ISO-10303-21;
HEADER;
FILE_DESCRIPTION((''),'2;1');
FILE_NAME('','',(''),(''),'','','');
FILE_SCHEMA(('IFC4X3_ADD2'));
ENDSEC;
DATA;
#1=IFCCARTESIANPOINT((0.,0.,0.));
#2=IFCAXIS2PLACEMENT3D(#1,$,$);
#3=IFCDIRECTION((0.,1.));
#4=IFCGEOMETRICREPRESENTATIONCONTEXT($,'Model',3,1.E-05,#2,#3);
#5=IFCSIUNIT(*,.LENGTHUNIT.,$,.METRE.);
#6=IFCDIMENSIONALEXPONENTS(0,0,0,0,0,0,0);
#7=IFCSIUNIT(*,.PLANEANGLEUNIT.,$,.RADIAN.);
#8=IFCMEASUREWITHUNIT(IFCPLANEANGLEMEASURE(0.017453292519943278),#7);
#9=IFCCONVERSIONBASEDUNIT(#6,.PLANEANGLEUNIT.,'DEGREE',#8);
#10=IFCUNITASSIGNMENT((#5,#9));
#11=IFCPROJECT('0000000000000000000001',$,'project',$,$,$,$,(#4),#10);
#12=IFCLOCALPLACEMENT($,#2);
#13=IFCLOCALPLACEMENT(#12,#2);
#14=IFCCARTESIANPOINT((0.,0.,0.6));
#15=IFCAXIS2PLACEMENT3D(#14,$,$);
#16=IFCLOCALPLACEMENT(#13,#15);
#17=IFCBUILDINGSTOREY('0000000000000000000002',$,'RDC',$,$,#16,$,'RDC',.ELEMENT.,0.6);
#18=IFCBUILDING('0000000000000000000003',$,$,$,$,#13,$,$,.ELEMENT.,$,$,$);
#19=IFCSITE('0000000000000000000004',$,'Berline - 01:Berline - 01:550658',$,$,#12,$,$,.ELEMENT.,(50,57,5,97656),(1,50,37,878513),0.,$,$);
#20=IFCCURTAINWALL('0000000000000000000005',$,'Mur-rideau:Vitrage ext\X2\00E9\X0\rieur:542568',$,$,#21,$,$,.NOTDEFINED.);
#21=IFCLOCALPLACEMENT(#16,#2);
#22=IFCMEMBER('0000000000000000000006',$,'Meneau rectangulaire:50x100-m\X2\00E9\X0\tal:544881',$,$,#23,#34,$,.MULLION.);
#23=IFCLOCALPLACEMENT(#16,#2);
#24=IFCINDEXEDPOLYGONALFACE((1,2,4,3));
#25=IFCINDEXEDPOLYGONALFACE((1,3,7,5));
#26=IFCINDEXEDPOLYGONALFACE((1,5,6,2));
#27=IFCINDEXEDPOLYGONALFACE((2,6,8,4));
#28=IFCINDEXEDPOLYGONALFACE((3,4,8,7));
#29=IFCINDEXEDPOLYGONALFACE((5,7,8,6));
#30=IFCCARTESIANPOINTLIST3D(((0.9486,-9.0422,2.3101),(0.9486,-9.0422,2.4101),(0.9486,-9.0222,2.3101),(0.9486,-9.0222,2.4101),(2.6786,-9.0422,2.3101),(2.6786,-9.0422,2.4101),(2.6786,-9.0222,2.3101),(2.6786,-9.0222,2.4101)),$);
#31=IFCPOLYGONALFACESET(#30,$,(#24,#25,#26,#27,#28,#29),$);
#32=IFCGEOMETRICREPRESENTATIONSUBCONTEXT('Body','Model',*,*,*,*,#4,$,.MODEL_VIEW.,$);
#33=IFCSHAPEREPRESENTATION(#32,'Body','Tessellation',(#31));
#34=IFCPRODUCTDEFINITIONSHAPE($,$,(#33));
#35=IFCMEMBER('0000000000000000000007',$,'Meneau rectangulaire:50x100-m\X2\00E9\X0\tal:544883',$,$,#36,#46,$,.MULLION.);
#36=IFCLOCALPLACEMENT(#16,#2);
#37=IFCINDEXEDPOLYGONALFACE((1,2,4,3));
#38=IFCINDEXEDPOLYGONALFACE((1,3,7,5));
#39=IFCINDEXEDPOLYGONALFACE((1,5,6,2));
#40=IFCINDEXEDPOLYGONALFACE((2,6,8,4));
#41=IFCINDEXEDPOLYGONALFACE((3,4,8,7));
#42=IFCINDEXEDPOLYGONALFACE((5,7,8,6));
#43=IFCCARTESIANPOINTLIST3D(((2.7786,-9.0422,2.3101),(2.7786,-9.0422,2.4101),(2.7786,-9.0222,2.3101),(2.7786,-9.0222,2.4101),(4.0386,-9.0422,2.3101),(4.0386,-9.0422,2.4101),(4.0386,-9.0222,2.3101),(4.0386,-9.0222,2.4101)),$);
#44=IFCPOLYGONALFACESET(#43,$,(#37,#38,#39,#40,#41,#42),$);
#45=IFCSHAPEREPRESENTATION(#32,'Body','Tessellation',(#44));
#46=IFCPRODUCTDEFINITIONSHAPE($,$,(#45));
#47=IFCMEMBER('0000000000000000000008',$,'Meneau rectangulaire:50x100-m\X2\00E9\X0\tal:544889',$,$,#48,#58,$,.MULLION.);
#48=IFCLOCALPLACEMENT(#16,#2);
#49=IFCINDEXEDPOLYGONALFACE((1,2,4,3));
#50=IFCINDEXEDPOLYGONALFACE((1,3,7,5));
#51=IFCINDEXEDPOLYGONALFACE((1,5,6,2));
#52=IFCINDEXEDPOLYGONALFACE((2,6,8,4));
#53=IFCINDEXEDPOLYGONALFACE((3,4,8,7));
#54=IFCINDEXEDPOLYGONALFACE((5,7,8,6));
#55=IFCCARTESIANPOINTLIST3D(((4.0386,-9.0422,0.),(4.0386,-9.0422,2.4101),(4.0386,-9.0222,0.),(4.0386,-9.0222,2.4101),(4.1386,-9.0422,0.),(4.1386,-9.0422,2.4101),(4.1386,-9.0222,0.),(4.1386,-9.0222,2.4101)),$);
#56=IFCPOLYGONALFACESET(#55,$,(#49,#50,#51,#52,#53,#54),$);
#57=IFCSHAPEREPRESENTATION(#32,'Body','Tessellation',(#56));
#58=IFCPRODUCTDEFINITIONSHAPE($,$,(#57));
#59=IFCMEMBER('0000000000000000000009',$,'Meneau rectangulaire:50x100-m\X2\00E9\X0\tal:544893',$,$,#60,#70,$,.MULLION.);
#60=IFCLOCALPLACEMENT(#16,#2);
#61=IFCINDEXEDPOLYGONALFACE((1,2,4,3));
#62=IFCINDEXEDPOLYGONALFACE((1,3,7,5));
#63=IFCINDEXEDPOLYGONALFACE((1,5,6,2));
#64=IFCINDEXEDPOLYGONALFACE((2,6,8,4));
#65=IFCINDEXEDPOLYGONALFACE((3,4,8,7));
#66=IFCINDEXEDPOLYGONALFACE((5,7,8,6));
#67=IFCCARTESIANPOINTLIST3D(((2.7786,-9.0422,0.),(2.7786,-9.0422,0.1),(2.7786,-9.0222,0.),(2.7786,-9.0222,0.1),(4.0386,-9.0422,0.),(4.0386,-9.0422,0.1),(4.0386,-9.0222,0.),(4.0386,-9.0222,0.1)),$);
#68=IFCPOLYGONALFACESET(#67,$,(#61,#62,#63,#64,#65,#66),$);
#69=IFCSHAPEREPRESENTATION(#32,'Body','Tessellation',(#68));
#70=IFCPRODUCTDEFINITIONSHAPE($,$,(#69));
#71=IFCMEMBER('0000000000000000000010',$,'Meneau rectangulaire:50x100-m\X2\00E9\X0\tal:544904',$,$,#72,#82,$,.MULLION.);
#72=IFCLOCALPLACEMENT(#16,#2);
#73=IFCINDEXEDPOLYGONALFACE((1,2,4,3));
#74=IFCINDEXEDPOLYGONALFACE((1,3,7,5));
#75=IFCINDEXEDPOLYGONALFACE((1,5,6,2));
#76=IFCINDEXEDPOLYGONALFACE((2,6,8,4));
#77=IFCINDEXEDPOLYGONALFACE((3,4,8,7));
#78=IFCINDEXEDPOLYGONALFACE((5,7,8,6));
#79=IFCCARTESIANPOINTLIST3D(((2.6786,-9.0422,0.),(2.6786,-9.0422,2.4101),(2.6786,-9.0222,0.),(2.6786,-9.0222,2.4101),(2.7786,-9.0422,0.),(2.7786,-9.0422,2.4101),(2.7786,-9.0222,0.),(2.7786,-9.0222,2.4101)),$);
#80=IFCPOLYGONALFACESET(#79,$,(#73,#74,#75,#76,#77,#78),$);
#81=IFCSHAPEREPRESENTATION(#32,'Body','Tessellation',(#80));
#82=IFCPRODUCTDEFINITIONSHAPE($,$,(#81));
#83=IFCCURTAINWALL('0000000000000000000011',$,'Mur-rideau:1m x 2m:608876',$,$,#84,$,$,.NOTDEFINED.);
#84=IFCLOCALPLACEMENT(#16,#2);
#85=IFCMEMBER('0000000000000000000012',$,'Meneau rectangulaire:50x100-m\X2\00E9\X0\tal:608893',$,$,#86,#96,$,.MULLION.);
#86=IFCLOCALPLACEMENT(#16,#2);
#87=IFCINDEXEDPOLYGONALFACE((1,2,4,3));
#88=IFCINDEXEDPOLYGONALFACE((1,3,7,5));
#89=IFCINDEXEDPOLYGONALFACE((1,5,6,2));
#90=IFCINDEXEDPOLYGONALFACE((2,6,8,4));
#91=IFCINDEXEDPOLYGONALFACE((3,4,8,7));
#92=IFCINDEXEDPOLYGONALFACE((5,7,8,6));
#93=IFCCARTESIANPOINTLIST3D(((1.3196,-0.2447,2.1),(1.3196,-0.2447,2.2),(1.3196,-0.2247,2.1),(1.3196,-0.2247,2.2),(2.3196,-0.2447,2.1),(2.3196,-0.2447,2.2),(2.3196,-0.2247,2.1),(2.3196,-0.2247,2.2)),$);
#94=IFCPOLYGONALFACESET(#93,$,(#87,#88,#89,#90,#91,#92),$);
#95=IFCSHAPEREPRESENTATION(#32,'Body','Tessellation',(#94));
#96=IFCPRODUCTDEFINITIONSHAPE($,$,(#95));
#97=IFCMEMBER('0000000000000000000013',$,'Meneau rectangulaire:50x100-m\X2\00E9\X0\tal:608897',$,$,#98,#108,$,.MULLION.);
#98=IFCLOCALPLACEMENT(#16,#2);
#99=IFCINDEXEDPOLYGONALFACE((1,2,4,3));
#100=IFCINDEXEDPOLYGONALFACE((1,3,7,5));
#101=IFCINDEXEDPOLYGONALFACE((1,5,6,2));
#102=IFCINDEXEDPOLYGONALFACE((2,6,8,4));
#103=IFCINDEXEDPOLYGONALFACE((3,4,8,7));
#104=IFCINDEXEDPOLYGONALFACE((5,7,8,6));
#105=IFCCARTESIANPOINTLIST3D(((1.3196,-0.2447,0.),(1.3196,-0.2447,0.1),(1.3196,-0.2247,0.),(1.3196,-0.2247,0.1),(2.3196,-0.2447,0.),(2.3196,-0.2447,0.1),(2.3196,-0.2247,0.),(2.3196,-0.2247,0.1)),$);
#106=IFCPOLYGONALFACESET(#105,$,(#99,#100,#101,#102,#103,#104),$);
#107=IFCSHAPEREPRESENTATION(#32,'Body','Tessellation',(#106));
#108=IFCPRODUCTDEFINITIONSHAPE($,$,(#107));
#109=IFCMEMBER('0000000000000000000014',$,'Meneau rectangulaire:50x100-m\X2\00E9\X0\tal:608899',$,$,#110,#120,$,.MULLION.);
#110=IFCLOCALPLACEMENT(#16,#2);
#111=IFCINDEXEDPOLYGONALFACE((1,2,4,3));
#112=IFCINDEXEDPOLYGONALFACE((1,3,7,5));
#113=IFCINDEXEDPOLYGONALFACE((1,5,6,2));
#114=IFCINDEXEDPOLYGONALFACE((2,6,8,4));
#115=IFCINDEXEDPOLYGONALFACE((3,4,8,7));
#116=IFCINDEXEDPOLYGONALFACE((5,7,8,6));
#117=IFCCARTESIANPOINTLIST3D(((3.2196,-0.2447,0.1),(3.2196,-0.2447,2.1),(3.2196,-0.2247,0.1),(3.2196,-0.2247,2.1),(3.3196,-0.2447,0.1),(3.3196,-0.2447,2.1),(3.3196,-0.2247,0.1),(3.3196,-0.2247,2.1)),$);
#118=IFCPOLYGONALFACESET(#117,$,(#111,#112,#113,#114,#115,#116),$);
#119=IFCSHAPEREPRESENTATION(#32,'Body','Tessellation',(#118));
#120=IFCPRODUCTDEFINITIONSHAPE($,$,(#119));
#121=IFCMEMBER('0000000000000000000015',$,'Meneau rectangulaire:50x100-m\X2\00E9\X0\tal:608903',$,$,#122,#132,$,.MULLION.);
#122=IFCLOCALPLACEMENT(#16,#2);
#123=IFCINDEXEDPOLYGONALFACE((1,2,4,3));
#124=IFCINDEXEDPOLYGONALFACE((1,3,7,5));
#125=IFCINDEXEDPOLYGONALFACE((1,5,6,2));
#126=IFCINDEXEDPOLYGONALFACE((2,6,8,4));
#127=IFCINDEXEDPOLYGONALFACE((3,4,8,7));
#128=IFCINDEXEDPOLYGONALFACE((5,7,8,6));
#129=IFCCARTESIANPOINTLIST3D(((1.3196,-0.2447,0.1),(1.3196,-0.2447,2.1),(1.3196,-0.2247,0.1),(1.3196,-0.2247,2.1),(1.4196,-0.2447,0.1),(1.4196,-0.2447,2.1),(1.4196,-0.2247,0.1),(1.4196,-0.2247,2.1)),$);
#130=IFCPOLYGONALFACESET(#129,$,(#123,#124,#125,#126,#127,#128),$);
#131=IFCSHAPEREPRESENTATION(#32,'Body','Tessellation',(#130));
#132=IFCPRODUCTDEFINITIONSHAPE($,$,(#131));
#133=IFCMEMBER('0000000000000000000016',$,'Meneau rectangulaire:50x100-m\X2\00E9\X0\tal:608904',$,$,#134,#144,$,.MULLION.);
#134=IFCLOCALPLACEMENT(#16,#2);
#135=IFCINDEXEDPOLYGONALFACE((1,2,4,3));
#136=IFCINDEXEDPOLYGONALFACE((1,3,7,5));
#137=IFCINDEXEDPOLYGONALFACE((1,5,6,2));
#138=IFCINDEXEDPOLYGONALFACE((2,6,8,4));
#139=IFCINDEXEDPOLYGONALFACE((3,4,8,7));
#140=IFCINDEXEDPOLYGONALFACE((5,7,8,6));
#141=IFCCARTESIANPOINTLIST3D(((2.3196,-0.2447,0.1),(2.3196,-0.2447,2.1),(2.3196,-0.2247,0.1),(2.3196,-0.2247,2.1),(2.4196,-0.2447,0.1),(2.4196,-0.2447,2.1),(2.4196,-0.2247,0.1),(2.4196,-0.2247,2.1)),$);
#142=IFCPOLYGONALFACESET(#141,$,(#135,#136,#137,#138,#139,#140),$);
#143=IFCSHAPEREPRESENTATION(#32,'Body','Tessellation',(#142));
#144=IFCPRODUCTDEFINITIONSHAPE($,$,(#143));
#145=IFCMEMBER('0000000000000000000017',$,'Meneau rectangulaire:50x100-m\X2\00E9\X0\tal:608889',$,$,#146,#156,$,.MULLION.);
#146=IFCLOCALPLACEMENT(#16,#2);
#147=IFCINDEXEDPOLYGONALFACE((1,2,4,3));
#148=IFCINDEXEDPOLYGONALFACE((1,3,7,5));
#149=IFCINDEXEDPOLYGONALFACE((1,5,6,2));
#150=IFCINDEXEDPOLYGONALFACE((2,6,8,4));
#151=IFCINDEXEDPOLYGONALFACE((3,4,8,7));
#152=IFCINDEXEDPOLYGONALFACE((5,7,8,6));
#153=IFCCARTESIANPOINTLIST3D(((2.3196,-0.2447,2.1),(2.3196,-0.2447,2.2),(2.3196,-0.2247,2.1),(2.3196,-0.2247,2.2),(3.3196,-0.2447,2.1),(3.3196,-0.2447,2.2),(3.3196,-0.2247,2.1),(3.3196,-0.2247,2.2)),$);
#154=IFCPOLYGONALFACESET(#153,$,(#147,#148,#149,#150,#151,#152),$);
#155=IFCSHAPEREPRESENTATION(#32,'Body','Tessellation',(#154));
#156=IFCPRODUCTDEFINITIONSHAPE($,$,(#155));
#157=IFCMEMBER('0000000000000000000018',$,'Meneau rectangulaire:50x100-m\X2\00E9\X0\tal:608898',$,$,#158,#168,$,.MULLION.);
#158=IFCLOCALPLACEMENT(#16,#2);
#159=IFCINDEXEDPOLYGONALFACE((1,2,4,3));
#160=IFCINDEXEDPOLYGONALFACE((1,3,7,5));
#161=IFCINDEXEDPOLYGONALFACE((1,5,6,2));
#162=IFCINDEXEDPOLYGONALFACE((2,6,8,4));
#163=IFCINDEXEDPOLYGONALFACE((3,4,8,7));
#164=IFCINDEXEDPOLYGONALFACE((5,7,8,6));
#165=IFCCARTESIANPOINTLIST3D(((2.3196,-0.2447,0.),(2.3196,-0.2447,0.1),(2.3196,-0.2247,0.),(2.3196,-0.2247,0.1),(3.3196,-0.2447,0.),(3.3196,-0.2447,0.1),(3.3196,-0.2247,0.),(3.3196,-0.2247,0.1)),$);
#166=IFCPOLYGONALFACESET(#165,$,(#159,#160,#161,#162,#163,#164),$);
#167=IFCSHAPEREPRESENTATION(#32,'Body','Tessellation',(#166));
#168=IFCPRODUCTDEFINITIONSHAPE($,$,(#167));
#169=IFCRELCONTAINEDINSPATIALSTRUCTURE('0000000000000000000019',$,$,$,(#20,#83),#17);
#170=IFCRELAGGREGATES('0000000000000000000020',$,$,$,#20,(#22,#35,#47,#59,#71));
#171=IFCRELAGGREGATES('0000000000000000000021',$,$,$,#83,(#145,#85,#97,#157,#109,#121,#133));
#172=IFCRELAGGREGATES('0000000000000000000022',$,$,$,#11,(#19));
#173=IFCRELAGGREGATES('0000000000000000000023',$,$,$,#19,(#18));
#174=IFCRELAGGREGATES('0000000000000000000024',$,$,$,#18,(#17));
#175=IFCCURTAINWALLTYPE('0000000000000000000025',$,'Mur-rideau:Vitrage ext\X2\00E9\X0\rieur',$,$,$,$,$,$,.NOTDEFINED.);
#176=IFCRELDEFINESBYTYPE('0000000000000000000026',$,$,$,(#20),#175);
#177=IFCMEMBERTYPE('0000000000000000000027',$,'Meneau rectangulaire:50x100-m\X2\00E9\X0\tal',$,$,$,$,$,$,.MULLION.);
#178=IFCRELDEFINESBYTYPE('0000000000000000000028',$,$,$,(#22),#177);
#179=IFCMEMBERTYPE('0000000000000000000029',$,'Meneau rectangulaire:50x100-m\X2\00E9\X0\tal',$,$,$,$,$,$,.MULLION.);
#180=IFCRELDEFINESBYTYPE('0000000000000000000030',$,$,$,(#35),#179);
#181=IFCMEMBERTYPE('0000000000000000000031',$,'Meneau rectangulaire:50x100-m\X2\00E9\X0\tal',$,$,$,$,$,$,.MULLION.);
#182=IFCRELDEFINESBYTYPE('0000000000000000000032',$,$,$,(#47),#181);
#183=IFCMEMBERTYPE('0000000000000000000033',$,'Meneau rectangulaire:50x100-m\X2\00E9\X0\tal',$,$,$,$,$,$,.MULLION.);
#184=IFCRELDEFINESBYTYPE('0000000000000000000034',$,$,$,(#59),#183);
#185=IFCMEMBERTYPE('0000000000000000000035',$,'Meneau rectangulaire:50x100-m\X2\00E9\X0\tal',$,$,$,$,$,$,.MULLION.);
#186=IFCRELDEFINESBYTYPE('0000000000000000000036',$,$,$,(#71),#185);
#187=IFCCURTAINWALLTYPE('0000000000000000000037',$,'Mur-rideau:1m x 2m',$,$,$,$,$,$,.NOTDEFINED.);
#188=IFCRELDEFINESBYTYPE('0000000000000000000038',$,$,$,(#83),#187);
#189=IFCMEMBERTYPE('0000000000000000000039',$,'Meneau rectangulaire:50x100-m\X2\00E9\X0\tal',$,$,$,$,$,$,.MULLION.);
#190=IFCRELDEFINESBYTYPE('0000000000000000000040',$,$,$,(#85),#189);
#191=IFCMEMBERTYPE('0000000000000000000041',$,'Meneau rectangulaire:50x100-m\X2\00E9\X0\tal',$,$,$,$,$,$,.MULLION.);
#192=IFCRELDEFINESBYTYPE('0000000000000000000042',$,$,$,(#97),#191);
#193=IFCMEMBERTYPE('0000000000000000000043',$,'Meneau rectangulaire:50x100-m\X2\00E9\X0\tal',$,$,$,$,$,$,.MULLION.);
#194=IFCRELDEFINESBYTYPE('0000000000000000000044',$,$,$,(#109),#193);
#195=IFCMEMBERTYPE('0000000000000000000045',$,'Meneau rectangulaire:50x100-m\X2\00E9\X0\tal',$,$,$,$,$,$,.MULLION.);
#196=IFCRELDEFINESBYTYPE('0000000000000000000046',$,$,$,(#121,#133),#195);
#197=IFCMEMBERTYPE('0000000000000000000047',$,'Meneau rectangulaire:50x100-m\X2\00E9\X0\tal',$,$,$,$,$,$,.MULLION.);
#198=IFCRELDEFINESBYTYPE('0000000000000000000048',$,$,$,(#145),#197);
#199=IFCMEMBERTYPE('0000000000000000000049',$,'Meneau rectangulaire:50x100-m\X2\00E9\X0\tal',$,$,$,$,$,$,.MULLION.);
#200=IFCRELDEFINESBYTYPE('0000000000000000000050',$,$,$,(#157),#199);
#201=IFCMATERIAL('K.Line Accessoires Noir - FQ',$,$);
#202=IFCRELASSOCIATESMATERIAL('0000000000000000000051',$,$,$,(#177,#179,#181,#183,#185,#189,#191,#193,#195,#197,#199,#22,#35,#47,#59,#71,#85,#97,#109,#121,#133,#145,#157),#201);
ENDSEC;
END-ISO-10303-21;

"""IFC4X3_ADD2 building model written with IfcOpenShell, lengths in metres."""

from ifc_helpers import new_model, entity, si_unit, converted_unit, direction, frame, origin, origin_2d_with_axis, place, context, subcontext, project, spatial, rectangle, extrude, source, transform, mapped, material, material_profile, profile_set, profile_usage, type_object, type_shapes, element, aggregate, save


model = new_model("IFC4X3_ADD2")

# Units and contexts
model_context = context("Model", 3, precision=1e-05, world=origin(), true_north=direction((0.0, 1.0)))
body_context = subcontext(model_context, "Body", "Model", "MODEL_VIEW")
ifc_project = project(units=[si_unit("LENGTHUNIT", "METRE"), converted_unit("PLANEANGLEUNIT", "DEGREE", entity("IfcPlaneAngleMeasure", 0.017453292519943278), si_unit("PLANEANGLEUNIT", "RADIAN"), dimensions=[0, 0, 0, 0, 0, 0, 0])], contexts=[model_context])

# Site, building, storey
site_placement = place(None, origin())
site = spatial("IfcSite", under=ifc_project, at=site_placement, Name="Berline - 01:Berline - 01:550658", CompositionType="ELEMENT", RefLatitude=(50, 57, 5, 97656), RefLongitude=(1, 50, 37, 878513), RefElevation=0.0)
building_placement = place(site_placement, origin())
building = spatial("IfcBuilding", under=site, at=building_placement, CompositionType="ELEMENT")
storey_placement = place(building_placement, frame((0.0, 0.0, 0.6)))
storey = spatial("IfcBuildingStorey", under=building, at=storey_placement, Name="RDC", LongName="RDC", CompositionType="ELEMENT", Elevation=0.6)

# Curtain walls, members
curtain_wall_type_1 = type_object("IfcCurtainWallType", Name="Mur-rideau:Vitrage extérieur", PredefinedType="NOTDEFINED")
curtain_wall_1_placement = place(storey_placement, frame((0.0, 0.0, -0.6)))
curtain_wall_1 = element("IfcCurtainWall", 1, at=curtain_wall_1_placement, inside=storey, type_object=curtain_wall_type_1, Name="Mur-rideau:Vitrage extérieur:542568", PredefinedType="NOTDEFINED")
ifc_material_1 = material(Name="K.Line Accessoires Noir - FQ")
ifc_material_profile = material_profile(ifc_material_1, rectangle(XDim=0.1, YDim=0.02, at=origin_2d_with_axis()), Name="50x100-métal")
ifc_profile_set = profile_set([ifc_material_profile], Name="50x100-métal")
ifc_profile_usage = profile_usage(ifc_profile_set)
member_type_1 = type_object("IfcMemberType", Name="Meneau rectangulaire:50x100-métal", PredefinedType="MULLION", material=ifc_profile_set)
shared_shape_1 = source(origin(), body_context, "Body", "SweptSolid", [
    extrude(rectangle(XDim=0.02, YDim=0.1, at=origin_2d_with_axis()), frame((-0.05, -0.01, -1.73), z_axis=(0.0, 0.0, 1.0), x_axis=(0.0, 1.0, 0.0)), (0.0, 0.0, 1.0), 1.73),
])
type_shapes(member_type_1, [shared_shape_1])
member_1_placement = place(curtain_wall_1_placement, frame((2.6786, -9.0422, 3.0101), z_axis=(1.0, 0.0, 0.0), x_axis=(0.0, 0.0, 1.0)))
member_1 = element("IfcMember", 2, at=member_1_placement, type_object=member_type_1, material=ifc_profile_usage, Name="Meneau rectangulaire:50x100-métal:544881", PredefinedType="MULLION", context=body_context, shape_type="MappedRepresentation", body=[
    mapped(shared_shape_1, transform((0.0, 0.0, 0.0), scale=1.0)),
])
member_type_2 = type_object("IfcMemberType", Name="Meneau rectangulaire:50x100-métal", PredefinedType="MULLION", material=ifc_profile_set)
shared_shape_2 = source(origin(), body_context, "Body", "SweptSolid", [
    extrude(rectangle(XDim=0.02, YDim=0.1, at=origin_2d_with_axis()), frame((-0.05, -0.01, -1.26), z_axis=(0.0, 0.0, 1.0), x_axis=(0.0, 1.0, 0.0)), (0.0, 0.0, 1.0), 1.26),
])
type_shapes(member_type_2, [shared_shape_2])
member_2_placement = place(curtain_wall_1_placement, frame((4.0386, -9.0422, 3.0101), z_axis=(1.0, 0.0, 0.0), x_axis=(0.0, 0.0, 1.0)))
member_2 = element("IfcMember", 3, at=member_2_placement, type_object=member_type_2, material=ifc_profile_usage, Name="Meneau rectangulaire:50x100-métal:544883", PredefinedType="MULLION", context=body_context, shape_type="MappedRepresentation", body=[
    mapped(shared_shape_2, transform((0.0, 0.0, 0.0), scale=1.0)),
])
member_type_3 = type_object("IfcMemberType", Name="Meneau rectangulaire:50x100-métal", PredefinedType="MULLION", material=ifc_profile_set)
shared_shape_3 = source(origin(), body_context, "Body", "SweptSolid", [
    extrude(rectangle(XDim=0.02, YDim=0.1, at=origin_2d_with_axis()), frame((-0.05, -0.01, -2.4101), z_axis=(0.0, 0.0, 1.0), x_axis=(0.0, 1.0, 0.0)), (0.0, 0.0, 1.0), 2.4101),
])
type_shapes(member_type_3, [shared_shape_3])
member_3_placement = place(curtain_wall_1_placement, frame((4.1386, -9.0422, 0.6), z_axis=(0.0, 0.0, -1.0), x_axis=(1.0, 0.0, 0.0)))
member_3 = element("IfcMember", 4, at=member_3_placement, type_object=member_type_3, material=ifc_profile_usage, Name="Meneau rectangulaire:50x100-métal:544889", PredefinedType="MULLION", context=body_context, shape_type="MappedRepresentation", body=[
    mapped(shared_shape_3, transform((0.0, 0.0, 0.0), scale=1.0)),
])
member_type_4 = type_object("IfcMemberType", Name="Meneau rectangulaire:50x100-métal", PredefinedType="MULLION", material=ifc_profile_set)
shared_shape_4 = source(origin(), body_context, "Body", "SweptSolid", [
    extrude(rectangle(XDim=0.1, YDim=0.02, at=origin_2d_with_axis()), frame((-0.05, -0.01, -1.26)), (0.0, 0.0, 1.0), 1.26),
])
type_shapes(member_type_4, [shared_shape_4])
member_4_placement = place(curtain_wall_1_placement, frame((2.7786, -9.0422, 0.6), z_axis=(-1.0, 0.0, 0.0), x_axis=(0.0, 0.0, -1.0)))
member_4 = element("IfcMember", 5, at=member_4_placement, type_object=member_type_4, material=ifc_profile_usage, Name="Meneau rectangulaire:50x100-métal:544893", PredefinedType="MULLION", context=body_context, shape_type="MappedRepresentation", body=[
    mapped(shared_shape_4, transform((0.0, 0.0, 0.0), scale=1.0)),
])
member_type_5 = type_object("IfcMemberType", Name="Meneau rectangulaire:50x100-métal", PredefinedType="MULLION", material=ifc_profile_set)
shared_shape_5 = source(origin(), body_context, "Body", "SweptSolid", [
    extrude(rectangle(XDim=0.02, YDim=0.1, at=origin_2d_with_axis()), frame((0.05, -0.01, -2.4101), z_axis=(0.0, 0.0, 1.0), x_axis=(0.0, 1.0, 0.0)), (0.0, 0.0, 1.0), 2.4101),
])
type_shapes(member_type_5, [shared_shape_5])
member_5_placement = place(curtain_wall_1_placement, frame((2.6786, -9.0422, 0.6), z_axis=(0.0, 0.0, -1.0), x_axis=(1.0, 0.0, 0.0)))
member_5 = element("IfcMember", 6, at=member_5_placement, type_object=member_type_5, material=ifc_profile_usage, Name="Meneau rectangulaire:50x100-métal:544904", PredefinedType="MULLION", context=body_context, shape_type="MappedRepresentation", body=[
    mapped(shared_shape_5, transform((0.0, 0.0, 0.0), scale=1.0)),
])
curtain_wall_type_2 = type_object("IfcCurtainWallType", Name="Mur-rideau:1m x 2m", PredefinedType="NOTDEFINED")
curtain_wall_2_placement = place(storey_placement, frame((0.0, 0.0, -0.6)))
curtain_wall_2 = element("IfcCurtainWall", 7, at=curtain_wall_2_placement, inside=storey, type_object=curtain_wall_type_2, Name="Mur-rideau:1m x 2m:608876", PredefinedType="NOTDEFINED")
member_type_6 = type_object("IfcMemberType", Name="Meneau rectangulaire:50x100-métal", PredefinedType="MULLION", material=ifc_profile_set)
shared_shape_6 = source(origin(), body_context, "Body", "SweptSolid", [
    extrude(rectangle(XDim=0.02, YDim=0.1, at=origin_2d_with_axis()), frame((-0.05, -0.01, -1.0), z_axis=(0.0, 0.0, 1.0), x_axis=(0.0, 1.0, 0.0)), (0.0, 0.0, 1.0), 1.0),
])
type_shapes(member_type_6, [shared_shape_6])
member_6_placement = place(curtain_wall_2_placement, frame((2.3196, -0.2447, 2.8), z_axis=(1.0, 0.0, 0.0), x_axis=(0.0, 0.0, 1.0)))
member_6 = element("IfcMember", 8, at=member_6_placement, type_object=member_type_6, material=ifc_profile_usage, Name="Meneau rectangulaire:50x100-métal:608893", PredefinedType="MULLION", context=body_context, shape_type="MappedRepresentation", body=[
    mapped(shared_shape_6, transform((0.0, 0.0, 0.0), scale=1.0)),
])
member_type_7 = type_object("IfcMemberType", Name="Meneau rectangulaire:50x100-métal", PredefinedType="MULLION", material=ifc_profile_set)
shared_shape_7 = source(origin(), body_context, "Body", "SweptSolid", [
    extrude(rectangle(XDim=0.1, YDim=0.02, at=origin_2d_with_axis()), frame((-0.05, -0.01, -1.0)), (0.0, 0.0, 1.0), 1.0),
])
type_shapes(member_type_7, [shared_shape_7])
member_7_placement = place(curtain_wall_2_placement, frame((1.3196, -0.2447, 0.6), z_axis=(-1.0, 0.0, 0.0), x_axis=(0.0, 0.0, -1.0)))
member_7 = element("IfcMember", 9, at=member_7_placement, type_object=member_type_7, material=ifc_profile_usage, Name="Meneau rectangulaire:50x100-métal:608897", PredefinedType="MULLION", context=body_context, shape_type="MappedRepresentation", body=[
    mapped(shared_shape_7, transform((0.0, 0.0, 0.0), scale=1.0)),
])
member_type_8 = type_object("IfcMemberType", Name="Meneau rectangulaire:50x100-métal", PredefinedType="MULLION", material=ifc_profile_set)
shared_shape_8 = source(origin(), body_context, "Body", "SweptSolid", [
    extrude(rectangle(XDim=0.02, YDim=0.1, at=origin_2d_with_axis()), frame((-0.05, -0.01, -2.0), z_axis=(0.0, 0.0, 1.0), x_axis=(0.0, 1.0, 0.0)), (0.0, 0.0, 1.0), 2.0),
])
type_shapes(member_type_8, [shared_shape_8])
member_8_placement = place(curtain_wall_2_placement, frame((3.3196, -0.2447, 0.7), z_axis=(0.0, 0.0, -1.0), x_axis=(1.0, 0.0, 0.0)))
member_8 = element("IfcMember", 10, at=member_8_placement, type_object=member_type_8, material=ifc_profile_usage, Name="Meneau rectangulaire:50x100-métal:608899", PredefinedType="MULLION", context=body_context, shape_type="MappedRepresentation", body=[
    mapped(shared_shape_8, transform((0.0, 0.0, 0.0), scale=1.0)),
])
member_type_9 = type_object("IfcMemberType", Name="Meneau rectangulaire:50x100-métal", PredefinedType="MULLION", material=ifc_profile_set)
shared_shape_9 = source(origin(), body_context, "Body", "SweptSolid", [
    extrude(rectangle(XDim=0.02, YDim=0.1, at=origin_2d_with_axis()), frame((0.05, -0.01, -2.0), z_axis=(0.0, 0.0, 1.0), x_axis=(0.0, 1.0, 0.0)), (0.0, 0.0, 1.0), 2.0),
])
type_shapes(member_type_9, [shared_shape_9])
member_9_placement = place(curtain_wall_2_placement, frame((1.3196, -0.2447, 0.7), z_axis=(0.0, 0.0, -1.0), x_axis=(1.0, 0.0, 0.0)))
member_9 = element("IfcMember", 11, at=member_9_placement, type_object=member_type_9, material=ifc_profile_usage, Name="Meneau rectangulaire:50x100-métal:608903", PredefinedType="MULLION", context=body_context, shape_type="MappedRepresentation", body=[
    mapped(shared_shape_9, transform((0.0, 0.0, 0.0), scale=1.0)),
])
member_10_placement = place(curtain_wall_2_placement, frame((2.3196, -0.2447, 0.7), z_axis=(0.0, 0.0, -1.0), x_axis=(1.0, 0.0, 0.0)))
member_10 = element("IfcMember", 12, at=member_10_placement, type_object=member_type_9, material=ifc_profile_usage, Name="Meneau rectangulaire:50x100-métal:608904", PredefinedType="MULLION", context=body_context, shape_type="MappedRepresentation", body=[
    mapped(shared_shape_9, transform((0.0, 0.0, 0.0), scale=1.0)),
])
member_type_10 = type_object("IfcMemberType", Name="Meneau rectangulaire:50x100-métal", PredefinedType="MULLION", material=ifc_profile_set)
shared_shape_10 = source(origin(), body_context, "Body", "SweptSolid", [
    extrude(rectangle(XDim=0.02, YDim=0.1, at=origin_2d_with_axis()), frame((-0.05, -0.01, -1.0), z_axis=(0.0, 0.0, 1.0), x_axis=(0.0, 1.0, 0.0)), (0.0, 0.0, 1.0), 1.0),
])
type_shapes(member_type_10, [shared_shape_10])
member_11_placement = place(curtain_wall_2_placement, frame((3.3196, -0.2447, 2.8), z_axis=(1.0, 0.0, 0.0), x_axis=(0.0, 0.0, 1.0)))
member_11 = element("IfcMember", 13, at=member_11_placement, type_object=member_type_10, material=ifc_profile_usage, Name="Meneau rectangulaire:50x100-métal:608889", PredefinedType="MULLION", context=body_context, shape_type="MappedRepresentation", body=[
    mapped(shared_shape_10, transform((0.0, 0.0, 0.0), scale=1.0)),
])
member_type_11 = type_object("IfcMemberType", Name="Meneau rectangulaire:50x100-métal", PredefinedType="MULLION", material=ifc_profile_set)
shared_shape_11 = source(origin(), body_context, "Body", "SweptSolid", [
    extrude(rectangle(XDim=0.1, YDim=0.02, at=origin_2d_with_axis()), frame((-0.05, -0.01, -1.0)), (0.0, 0.0, 1.0), 1.0),
])
type_shapes(member_type_11, [shared_shape_11])
member_12_placement = place(curtain_wall_2_placement, frame((2.3196, -0.2447, 0.6), z_axis=(-1.0, 0.0, 0.0), x_axis=(0.0, 0.0, -1.0)))
member_12 = element("IfcMember", 14, at=member_12_placement, type_object=member_type_11, material=ifc_profile_usage, Name="Meneau rectangulaire:50x100-métal:608898", PredefinedType="MULLION", context=body_context, shape_type="MappedRepresentation", body=[
    mapped(shared_shape_11, transform((0.0, 0.0, 0.0), scale=1.0)),
])

aggregate(curtain_wall_1, [member_1, member_2, member_3, member_4, member_5])
aggregate(curtain_wall_2, [member_11, member_6, member_7, member_12, member_8, member_9, member_10])

save(model, "model.ifc")
